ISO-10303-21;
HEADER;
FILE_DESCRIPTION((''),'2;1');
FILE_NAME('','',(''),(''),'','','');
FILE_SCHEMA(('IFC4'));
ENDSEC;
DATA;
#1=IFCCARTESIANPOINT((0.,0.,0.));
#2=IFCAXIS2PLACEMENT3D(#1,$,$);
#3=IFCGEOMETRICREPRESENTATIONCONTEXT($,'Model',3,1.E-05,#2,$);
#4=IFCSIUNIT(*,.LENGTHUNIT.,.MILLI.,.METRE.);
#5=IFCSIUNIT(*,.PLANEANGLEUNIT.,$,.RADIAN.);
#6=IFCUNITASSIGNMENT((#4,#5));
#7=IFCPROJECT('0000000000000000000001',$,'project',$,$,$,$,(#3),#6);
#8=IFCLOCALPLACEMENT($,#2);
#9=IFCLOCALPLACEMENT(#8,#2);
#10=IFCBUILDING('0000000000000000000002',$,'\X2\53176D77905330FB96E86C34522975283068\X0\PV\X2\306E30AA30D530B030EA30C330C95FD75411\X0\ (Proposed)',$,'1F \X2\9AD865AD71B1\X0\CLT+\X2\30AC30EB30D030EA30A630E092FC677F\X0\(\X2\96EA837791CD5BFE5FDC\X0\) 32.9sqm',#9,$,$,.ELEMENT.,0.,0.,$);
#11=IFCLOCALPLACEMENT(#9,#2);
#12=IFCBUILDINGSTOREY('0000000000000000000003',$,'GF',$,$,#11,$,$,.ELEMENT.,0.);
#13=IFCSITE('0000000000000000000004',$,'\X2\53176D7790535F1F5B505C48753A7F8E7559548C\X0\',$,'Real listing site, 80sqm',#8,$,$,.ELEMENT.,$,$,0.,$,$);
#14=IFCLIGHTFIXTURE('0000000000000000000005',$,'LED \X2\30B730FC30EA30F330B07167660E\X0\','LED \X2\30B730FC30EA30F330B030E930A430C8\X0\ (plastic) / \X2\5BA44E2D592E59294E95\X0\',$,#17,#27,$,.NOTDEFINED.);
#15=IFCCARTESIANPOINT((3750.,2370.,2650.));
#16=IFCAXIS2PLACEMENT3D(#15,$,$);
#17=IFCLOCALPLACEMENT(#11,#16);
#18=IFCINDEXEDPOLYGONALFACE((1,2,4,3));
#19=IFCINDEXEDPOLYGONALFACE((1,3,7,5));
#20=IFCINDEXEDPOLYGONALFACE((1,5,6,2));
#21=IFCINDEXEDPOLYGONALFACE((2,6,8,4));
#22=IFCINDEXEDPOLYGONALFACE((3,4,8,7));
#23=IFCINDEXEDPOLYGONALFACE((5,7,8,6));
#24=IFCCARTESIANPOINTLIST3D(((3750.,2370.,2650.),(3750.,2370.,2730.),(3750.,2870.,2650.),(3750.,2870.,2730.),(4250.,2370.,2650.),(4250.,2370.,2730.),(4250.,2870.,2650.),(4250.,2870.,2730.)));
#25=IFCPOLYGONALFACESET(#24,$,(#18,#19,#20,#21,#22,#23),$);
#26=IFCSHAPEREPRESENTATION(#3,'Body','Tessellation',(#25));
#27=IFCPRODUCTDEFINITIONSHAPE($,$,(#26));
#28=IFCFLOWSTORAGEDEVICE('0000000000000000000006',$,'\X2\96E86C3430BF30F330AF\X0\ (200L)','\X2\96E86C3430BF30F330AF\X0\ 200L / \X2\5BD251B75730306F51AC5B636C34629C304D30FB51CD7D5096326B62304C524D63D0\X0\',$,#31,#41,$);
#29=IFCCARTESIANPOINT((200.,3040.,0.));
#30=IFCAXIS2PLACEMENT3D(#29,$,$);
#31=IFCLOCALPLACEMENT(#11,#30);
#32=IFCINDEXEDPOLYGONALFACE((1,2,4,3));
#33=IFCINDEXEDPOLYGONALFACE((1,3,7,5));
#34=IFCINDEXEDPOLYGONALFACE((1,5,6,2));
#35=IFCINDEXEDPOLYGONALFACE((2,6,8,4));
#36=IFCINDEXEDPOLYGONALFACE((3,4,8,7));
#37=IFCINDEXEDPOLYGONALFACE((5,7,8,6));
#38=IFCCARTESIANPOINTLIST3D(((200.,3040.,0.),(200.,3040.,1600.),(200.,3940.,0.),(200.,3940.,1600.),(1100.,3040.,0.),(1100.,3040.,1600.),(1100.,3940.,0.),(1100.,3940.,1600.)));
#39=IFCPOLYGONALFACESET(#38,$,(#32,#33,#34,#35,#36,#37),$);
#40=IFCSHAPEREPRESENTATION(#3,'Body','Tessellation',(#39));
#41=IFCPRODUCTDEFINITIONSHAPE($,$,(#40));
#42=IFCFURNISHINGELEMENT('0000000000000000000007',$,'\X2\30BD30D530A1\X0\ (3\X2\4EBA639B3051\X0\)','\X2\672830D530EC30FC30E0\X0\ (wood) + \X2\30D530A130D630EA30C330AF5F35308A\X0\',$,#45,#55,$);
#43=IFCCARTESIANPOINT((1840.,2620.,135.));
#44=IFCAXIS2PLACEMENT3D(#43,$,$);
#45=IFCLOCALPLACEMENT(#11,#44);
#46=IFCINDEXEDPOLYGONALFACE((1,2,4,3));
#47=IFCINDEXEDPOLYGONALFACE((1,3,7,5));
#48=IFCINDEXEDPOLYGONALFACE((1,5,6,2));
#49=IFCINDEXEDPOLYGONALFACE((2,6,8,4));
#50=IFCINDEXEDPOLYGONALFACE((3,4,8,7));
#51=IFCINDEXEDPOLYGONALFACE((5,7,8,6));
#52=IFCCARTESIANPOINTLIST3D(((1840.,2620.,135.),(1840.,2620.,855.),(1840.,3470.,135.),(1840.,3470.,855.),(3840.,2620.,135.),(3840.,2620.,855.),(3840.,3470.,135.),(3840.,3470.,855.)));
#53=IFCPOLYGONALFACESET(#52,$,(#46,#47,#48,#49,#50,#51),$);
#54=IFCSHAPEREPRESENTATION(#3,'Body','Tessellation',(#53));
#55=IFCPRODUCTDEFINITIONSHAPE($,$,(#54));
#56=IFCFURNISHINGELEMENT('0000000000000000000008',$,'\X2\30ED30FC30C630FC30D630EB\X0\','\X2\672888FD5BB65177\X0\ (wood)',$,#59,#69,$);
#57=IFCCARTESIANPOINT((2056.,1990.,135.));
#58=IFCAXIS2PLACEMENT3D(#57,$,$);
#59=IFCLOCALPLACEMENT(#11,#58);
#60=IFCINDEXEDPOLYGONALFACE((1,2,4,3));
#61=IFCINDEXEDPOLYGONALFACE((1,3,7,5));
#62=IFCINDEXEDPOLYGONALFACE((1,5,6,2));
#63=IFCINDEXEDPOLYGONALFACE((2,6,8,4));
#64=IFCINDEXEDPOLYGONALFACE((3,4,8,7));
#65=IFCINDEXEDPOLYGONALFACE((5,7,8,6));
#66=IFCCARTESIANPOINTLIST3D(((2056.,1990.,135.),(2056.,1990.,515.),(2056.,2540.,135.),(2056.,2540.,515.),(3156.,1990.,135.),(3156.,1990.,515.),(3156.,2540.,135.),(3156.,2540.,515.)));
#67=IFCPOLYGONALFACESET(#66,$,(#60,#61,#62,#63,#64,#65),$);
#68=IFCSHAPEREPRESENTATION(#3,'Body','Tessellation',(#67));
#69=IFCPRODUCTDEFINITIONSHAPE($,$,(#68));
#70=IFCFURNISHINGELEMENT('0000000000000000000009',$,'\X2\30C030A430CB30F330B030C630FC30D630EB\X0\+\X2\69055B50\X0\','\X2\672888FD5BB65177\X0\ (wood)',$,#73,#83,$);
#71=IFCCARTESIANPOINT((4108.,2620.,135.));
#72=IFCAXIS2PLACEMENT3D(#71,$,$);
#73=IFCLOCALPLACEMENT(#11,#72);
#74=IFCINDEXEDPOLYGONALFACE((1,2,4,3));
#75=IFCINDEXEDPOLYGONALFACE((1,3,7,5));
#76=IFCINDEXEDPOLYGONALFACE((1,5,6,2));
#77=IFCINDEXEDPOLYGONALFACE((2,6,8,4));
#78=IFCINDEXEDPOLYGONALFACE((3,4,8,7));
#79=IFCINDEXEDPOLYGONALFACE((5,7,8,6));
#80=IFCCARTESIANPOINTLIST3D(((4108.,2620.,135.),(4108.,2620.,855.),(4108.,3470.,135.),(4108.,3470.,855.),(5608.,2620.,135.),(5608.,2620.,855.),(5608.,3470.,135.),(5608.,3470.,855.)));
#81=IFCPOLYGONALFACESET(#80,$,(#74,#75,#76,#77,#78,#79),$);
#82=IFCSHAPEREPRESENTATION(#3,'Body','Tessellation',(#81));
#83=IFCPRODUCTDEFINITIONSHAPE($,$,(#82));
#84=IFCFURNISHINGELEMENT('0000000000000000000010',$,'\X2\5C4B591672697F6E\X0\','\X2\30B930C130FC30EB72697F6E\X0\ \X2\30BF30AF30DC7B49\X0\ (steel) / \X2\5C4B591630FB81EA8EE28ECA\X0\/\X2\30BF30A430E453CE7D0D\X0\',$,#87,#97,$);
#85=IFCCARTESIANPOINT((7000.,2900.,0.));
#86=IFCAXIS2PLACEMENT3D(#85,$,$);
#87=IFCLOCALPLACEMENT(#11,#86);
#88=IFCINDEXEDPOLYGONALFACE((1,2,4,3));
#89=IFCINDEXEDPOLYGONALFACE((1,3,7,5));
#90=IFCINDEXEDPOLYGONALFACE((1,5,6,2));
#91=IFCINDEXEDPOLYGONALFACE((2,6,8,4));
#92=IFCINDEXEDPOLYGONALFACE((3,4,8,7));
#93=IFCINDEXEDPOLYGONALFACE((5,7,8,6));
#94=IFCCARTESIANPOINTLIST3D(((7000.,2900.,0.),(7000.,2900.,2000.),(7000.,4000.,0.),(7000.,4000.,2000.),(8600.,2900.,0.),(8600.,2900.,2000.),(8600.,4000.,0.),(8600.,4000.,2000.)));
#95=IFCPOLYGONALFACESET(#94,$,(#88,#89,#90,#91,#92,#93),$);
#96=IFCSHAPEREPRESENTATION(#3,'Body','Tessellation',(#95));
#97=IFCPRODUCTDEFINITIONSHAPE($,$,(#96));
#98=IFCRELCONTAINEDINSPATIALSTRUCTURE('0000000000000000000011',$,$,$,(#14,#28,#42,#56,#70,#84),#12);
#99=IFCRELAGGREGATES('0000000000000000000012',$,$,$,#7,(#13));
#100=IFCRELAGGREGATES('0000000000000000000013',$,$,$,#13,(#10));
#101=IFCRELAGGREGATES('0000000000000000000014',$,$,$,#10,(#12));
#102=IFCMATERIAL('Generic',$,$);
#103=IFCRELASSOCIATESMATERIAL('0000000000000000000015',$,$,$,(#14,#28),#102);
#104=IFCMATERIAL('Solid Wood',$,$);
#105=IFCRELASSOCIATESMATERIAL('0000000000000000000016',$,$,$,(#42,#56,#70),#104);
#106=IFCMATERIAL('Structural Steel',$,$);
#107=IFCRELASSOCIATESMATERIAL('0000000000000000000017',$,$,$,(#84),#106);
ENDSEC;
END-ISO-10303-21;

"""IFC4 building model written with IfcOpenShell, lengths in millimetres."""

from ifc_helpers import new_model, si_unit, frame, frame_2d, origin, place, context, project, spatial, rectangle, extrude, material, element, save


model = new_model("IFC4")

# Units and contexts
model_context = context("Model", 3, precision=1e-05, world=origin())
ifc_project = project(units=[si_unit("LENGTHUNIT", "METRE", prefix="MILLI"), si_unit("PLANEANGLEUNIT", "RADIAN")], contexts=[model_context])

# Site, building, storey
site_placement = place(None, origin())
site = spatial("IfcSite", under=ifc_project, at=site_placement, Name="北海道弟子屈町美留和", ObjectType="Real listing site, 80sqm", CompositionType="ELEMENT", RefElevation=0.0)
building_placement = place(site_placement, origin())
building = spatial("IfcBuilding", under=site, at=building_placement, Name="北海道・雨水利用とPVのオフグリッド志向 (Proposed)", ObjectType="1F 高断熱CLT+ガルバリウム鋼板(雪荷重対応) 32.9sqm", CompositionType="ELEMENT", ElevationOfRefHeight=0.0, ElevationOfTerrain=0.0)
storey_placement = place(building_placement, origin())
storey = spatial("IfcBuildingStorey", under=building, at=storey_placement, Name="GF", CompositionType="ELEMENT", Elevation=0.0)

# Shared definitions
ifc_material_1 = material(Name="Solid Wood")

# Shared definitions
ifc_material_2 = material(Name="Structural Steel")

# Light fixture
ifc_material_3 = material(Name="Generic")
light_fixture_placement = place(storey_placement, frame((3750.0, 2370.0, 2650.0)))
element("IfcLightFixture", 1, at=light_fixture_placement, inside=storey, material=ifc_material_3, Name="LED シーリング照明", Description="LED シーリングライト (plastic) / 室中央天井", PredefinedType="NOTDEFINED", context=model_context, shape_type="SweptSolid", body=[
    extrude(rectangle(XDim=500.0, YDim=500.0, at=frame_2d((250.0, 250.0))), frame((3750.0, 2370.0, 2650.0)), (0.0, 0.0, 1.0), 80.0),
])

# Flow storage device
flow_storage_device_placement = place(storey_placement, frame((200.0, 3040.0, 0.0)))
element("IfcFlowStorageDevice", 2, at=flow_storage_device_placement, inside=storey, material=ifc_material_3, Name="雨水タンク (200L)", Description="雨水タンク 200L / 寒冷地は冬季水抜き・凍結防止が前提", context=model_context, shape_type="SweptSolid", body=[
    extrude(rectangle(XDim=900.0, YDim=900.0, at=frame_2d((450.0, 450.0))), frame((200.0, 3040.0, 0.0)), (0.0, 0.0, 1.0), 1600.0),
])

# Furnishing elements
furnishing_1_placement = place(storey_placement, frame((1840.0, 2620.0, 135.0)))
element("IfcFurnishingElement", 3, at=furnishing_1_placement, inside=storey, material=ifc_material_1, Name="ソファ (3人掛け)", Description="木フレーム (wood) + ファブリック張り", context=model_context, shape_type="SweptSolid", body=[
    extrude(rectangle(XDim=2000.0, YDim=850.0, at=frame_2d((1000.0, 425.0))), frame((1840.0, 2620.0, 135.0)), (0.0, 0.0, 1.0), 720.0),
])
furnishing_2_placement = place(storey_placement, frame((2056.0, 1990.0, 135.0)))
element("IfcFurnishingElement", 4, at=furnishing_2_placement, inside=storey, material=ifc_material_1, Name="ローテーブル", Description="木製家具 (wood)", context=model_context, shape_type="SweptSolid", body=[
    extrude(rectangle(XDim=1100.0, YDim=550.0, at=frame_2d((550.0, 275.0))), frame((2056.0, 1990.0, 135.0)), (0.0, 0.0, 1.0), 380.0),
])
furnishing_3_placement = place(storey_placement, frame((4108.0, 2620.0, 135.0)))
element("IfcFurnishingElement", 5, at=furnishing_3_placement, inside=storey, material=ifc_material_1, Name="ダイニングテーブル+椅子", Description="木製家具 (wood)", context=model_context, shape_type="SweptSolid", body=[
    extrude(rectangle(XDim=1500.0, YDim=850.0, at=frame_2d((750.0, 425.0))), frame((4108.0, 2620.0, 135.0)), (0.0, 0.0, 1.0), 720.0),
])
furnishing_4_placement = place(storey_placement, frame((7000.0, 2900.0, 0.0)))
element("IfcFurnishingElement", 6, at=furnishing_4_placement, inside=storey, material=ifc_material_2, Name="屋外物置", Description="スチール物置 タクボ等 (steel) / 屋外・自転車/タイヤ収納", context=model_context, shape_type="SweptSolid", body=[
    extrude(rectangle(XDim=1600.0, YDim=1100.0, at=frame_2d((800.0, 550.0))), frame((7000.0, 2900.0, 0.0)), (0.0, 0.0, 1.0), 2000.0),
])

save(model, "model.ifc")
